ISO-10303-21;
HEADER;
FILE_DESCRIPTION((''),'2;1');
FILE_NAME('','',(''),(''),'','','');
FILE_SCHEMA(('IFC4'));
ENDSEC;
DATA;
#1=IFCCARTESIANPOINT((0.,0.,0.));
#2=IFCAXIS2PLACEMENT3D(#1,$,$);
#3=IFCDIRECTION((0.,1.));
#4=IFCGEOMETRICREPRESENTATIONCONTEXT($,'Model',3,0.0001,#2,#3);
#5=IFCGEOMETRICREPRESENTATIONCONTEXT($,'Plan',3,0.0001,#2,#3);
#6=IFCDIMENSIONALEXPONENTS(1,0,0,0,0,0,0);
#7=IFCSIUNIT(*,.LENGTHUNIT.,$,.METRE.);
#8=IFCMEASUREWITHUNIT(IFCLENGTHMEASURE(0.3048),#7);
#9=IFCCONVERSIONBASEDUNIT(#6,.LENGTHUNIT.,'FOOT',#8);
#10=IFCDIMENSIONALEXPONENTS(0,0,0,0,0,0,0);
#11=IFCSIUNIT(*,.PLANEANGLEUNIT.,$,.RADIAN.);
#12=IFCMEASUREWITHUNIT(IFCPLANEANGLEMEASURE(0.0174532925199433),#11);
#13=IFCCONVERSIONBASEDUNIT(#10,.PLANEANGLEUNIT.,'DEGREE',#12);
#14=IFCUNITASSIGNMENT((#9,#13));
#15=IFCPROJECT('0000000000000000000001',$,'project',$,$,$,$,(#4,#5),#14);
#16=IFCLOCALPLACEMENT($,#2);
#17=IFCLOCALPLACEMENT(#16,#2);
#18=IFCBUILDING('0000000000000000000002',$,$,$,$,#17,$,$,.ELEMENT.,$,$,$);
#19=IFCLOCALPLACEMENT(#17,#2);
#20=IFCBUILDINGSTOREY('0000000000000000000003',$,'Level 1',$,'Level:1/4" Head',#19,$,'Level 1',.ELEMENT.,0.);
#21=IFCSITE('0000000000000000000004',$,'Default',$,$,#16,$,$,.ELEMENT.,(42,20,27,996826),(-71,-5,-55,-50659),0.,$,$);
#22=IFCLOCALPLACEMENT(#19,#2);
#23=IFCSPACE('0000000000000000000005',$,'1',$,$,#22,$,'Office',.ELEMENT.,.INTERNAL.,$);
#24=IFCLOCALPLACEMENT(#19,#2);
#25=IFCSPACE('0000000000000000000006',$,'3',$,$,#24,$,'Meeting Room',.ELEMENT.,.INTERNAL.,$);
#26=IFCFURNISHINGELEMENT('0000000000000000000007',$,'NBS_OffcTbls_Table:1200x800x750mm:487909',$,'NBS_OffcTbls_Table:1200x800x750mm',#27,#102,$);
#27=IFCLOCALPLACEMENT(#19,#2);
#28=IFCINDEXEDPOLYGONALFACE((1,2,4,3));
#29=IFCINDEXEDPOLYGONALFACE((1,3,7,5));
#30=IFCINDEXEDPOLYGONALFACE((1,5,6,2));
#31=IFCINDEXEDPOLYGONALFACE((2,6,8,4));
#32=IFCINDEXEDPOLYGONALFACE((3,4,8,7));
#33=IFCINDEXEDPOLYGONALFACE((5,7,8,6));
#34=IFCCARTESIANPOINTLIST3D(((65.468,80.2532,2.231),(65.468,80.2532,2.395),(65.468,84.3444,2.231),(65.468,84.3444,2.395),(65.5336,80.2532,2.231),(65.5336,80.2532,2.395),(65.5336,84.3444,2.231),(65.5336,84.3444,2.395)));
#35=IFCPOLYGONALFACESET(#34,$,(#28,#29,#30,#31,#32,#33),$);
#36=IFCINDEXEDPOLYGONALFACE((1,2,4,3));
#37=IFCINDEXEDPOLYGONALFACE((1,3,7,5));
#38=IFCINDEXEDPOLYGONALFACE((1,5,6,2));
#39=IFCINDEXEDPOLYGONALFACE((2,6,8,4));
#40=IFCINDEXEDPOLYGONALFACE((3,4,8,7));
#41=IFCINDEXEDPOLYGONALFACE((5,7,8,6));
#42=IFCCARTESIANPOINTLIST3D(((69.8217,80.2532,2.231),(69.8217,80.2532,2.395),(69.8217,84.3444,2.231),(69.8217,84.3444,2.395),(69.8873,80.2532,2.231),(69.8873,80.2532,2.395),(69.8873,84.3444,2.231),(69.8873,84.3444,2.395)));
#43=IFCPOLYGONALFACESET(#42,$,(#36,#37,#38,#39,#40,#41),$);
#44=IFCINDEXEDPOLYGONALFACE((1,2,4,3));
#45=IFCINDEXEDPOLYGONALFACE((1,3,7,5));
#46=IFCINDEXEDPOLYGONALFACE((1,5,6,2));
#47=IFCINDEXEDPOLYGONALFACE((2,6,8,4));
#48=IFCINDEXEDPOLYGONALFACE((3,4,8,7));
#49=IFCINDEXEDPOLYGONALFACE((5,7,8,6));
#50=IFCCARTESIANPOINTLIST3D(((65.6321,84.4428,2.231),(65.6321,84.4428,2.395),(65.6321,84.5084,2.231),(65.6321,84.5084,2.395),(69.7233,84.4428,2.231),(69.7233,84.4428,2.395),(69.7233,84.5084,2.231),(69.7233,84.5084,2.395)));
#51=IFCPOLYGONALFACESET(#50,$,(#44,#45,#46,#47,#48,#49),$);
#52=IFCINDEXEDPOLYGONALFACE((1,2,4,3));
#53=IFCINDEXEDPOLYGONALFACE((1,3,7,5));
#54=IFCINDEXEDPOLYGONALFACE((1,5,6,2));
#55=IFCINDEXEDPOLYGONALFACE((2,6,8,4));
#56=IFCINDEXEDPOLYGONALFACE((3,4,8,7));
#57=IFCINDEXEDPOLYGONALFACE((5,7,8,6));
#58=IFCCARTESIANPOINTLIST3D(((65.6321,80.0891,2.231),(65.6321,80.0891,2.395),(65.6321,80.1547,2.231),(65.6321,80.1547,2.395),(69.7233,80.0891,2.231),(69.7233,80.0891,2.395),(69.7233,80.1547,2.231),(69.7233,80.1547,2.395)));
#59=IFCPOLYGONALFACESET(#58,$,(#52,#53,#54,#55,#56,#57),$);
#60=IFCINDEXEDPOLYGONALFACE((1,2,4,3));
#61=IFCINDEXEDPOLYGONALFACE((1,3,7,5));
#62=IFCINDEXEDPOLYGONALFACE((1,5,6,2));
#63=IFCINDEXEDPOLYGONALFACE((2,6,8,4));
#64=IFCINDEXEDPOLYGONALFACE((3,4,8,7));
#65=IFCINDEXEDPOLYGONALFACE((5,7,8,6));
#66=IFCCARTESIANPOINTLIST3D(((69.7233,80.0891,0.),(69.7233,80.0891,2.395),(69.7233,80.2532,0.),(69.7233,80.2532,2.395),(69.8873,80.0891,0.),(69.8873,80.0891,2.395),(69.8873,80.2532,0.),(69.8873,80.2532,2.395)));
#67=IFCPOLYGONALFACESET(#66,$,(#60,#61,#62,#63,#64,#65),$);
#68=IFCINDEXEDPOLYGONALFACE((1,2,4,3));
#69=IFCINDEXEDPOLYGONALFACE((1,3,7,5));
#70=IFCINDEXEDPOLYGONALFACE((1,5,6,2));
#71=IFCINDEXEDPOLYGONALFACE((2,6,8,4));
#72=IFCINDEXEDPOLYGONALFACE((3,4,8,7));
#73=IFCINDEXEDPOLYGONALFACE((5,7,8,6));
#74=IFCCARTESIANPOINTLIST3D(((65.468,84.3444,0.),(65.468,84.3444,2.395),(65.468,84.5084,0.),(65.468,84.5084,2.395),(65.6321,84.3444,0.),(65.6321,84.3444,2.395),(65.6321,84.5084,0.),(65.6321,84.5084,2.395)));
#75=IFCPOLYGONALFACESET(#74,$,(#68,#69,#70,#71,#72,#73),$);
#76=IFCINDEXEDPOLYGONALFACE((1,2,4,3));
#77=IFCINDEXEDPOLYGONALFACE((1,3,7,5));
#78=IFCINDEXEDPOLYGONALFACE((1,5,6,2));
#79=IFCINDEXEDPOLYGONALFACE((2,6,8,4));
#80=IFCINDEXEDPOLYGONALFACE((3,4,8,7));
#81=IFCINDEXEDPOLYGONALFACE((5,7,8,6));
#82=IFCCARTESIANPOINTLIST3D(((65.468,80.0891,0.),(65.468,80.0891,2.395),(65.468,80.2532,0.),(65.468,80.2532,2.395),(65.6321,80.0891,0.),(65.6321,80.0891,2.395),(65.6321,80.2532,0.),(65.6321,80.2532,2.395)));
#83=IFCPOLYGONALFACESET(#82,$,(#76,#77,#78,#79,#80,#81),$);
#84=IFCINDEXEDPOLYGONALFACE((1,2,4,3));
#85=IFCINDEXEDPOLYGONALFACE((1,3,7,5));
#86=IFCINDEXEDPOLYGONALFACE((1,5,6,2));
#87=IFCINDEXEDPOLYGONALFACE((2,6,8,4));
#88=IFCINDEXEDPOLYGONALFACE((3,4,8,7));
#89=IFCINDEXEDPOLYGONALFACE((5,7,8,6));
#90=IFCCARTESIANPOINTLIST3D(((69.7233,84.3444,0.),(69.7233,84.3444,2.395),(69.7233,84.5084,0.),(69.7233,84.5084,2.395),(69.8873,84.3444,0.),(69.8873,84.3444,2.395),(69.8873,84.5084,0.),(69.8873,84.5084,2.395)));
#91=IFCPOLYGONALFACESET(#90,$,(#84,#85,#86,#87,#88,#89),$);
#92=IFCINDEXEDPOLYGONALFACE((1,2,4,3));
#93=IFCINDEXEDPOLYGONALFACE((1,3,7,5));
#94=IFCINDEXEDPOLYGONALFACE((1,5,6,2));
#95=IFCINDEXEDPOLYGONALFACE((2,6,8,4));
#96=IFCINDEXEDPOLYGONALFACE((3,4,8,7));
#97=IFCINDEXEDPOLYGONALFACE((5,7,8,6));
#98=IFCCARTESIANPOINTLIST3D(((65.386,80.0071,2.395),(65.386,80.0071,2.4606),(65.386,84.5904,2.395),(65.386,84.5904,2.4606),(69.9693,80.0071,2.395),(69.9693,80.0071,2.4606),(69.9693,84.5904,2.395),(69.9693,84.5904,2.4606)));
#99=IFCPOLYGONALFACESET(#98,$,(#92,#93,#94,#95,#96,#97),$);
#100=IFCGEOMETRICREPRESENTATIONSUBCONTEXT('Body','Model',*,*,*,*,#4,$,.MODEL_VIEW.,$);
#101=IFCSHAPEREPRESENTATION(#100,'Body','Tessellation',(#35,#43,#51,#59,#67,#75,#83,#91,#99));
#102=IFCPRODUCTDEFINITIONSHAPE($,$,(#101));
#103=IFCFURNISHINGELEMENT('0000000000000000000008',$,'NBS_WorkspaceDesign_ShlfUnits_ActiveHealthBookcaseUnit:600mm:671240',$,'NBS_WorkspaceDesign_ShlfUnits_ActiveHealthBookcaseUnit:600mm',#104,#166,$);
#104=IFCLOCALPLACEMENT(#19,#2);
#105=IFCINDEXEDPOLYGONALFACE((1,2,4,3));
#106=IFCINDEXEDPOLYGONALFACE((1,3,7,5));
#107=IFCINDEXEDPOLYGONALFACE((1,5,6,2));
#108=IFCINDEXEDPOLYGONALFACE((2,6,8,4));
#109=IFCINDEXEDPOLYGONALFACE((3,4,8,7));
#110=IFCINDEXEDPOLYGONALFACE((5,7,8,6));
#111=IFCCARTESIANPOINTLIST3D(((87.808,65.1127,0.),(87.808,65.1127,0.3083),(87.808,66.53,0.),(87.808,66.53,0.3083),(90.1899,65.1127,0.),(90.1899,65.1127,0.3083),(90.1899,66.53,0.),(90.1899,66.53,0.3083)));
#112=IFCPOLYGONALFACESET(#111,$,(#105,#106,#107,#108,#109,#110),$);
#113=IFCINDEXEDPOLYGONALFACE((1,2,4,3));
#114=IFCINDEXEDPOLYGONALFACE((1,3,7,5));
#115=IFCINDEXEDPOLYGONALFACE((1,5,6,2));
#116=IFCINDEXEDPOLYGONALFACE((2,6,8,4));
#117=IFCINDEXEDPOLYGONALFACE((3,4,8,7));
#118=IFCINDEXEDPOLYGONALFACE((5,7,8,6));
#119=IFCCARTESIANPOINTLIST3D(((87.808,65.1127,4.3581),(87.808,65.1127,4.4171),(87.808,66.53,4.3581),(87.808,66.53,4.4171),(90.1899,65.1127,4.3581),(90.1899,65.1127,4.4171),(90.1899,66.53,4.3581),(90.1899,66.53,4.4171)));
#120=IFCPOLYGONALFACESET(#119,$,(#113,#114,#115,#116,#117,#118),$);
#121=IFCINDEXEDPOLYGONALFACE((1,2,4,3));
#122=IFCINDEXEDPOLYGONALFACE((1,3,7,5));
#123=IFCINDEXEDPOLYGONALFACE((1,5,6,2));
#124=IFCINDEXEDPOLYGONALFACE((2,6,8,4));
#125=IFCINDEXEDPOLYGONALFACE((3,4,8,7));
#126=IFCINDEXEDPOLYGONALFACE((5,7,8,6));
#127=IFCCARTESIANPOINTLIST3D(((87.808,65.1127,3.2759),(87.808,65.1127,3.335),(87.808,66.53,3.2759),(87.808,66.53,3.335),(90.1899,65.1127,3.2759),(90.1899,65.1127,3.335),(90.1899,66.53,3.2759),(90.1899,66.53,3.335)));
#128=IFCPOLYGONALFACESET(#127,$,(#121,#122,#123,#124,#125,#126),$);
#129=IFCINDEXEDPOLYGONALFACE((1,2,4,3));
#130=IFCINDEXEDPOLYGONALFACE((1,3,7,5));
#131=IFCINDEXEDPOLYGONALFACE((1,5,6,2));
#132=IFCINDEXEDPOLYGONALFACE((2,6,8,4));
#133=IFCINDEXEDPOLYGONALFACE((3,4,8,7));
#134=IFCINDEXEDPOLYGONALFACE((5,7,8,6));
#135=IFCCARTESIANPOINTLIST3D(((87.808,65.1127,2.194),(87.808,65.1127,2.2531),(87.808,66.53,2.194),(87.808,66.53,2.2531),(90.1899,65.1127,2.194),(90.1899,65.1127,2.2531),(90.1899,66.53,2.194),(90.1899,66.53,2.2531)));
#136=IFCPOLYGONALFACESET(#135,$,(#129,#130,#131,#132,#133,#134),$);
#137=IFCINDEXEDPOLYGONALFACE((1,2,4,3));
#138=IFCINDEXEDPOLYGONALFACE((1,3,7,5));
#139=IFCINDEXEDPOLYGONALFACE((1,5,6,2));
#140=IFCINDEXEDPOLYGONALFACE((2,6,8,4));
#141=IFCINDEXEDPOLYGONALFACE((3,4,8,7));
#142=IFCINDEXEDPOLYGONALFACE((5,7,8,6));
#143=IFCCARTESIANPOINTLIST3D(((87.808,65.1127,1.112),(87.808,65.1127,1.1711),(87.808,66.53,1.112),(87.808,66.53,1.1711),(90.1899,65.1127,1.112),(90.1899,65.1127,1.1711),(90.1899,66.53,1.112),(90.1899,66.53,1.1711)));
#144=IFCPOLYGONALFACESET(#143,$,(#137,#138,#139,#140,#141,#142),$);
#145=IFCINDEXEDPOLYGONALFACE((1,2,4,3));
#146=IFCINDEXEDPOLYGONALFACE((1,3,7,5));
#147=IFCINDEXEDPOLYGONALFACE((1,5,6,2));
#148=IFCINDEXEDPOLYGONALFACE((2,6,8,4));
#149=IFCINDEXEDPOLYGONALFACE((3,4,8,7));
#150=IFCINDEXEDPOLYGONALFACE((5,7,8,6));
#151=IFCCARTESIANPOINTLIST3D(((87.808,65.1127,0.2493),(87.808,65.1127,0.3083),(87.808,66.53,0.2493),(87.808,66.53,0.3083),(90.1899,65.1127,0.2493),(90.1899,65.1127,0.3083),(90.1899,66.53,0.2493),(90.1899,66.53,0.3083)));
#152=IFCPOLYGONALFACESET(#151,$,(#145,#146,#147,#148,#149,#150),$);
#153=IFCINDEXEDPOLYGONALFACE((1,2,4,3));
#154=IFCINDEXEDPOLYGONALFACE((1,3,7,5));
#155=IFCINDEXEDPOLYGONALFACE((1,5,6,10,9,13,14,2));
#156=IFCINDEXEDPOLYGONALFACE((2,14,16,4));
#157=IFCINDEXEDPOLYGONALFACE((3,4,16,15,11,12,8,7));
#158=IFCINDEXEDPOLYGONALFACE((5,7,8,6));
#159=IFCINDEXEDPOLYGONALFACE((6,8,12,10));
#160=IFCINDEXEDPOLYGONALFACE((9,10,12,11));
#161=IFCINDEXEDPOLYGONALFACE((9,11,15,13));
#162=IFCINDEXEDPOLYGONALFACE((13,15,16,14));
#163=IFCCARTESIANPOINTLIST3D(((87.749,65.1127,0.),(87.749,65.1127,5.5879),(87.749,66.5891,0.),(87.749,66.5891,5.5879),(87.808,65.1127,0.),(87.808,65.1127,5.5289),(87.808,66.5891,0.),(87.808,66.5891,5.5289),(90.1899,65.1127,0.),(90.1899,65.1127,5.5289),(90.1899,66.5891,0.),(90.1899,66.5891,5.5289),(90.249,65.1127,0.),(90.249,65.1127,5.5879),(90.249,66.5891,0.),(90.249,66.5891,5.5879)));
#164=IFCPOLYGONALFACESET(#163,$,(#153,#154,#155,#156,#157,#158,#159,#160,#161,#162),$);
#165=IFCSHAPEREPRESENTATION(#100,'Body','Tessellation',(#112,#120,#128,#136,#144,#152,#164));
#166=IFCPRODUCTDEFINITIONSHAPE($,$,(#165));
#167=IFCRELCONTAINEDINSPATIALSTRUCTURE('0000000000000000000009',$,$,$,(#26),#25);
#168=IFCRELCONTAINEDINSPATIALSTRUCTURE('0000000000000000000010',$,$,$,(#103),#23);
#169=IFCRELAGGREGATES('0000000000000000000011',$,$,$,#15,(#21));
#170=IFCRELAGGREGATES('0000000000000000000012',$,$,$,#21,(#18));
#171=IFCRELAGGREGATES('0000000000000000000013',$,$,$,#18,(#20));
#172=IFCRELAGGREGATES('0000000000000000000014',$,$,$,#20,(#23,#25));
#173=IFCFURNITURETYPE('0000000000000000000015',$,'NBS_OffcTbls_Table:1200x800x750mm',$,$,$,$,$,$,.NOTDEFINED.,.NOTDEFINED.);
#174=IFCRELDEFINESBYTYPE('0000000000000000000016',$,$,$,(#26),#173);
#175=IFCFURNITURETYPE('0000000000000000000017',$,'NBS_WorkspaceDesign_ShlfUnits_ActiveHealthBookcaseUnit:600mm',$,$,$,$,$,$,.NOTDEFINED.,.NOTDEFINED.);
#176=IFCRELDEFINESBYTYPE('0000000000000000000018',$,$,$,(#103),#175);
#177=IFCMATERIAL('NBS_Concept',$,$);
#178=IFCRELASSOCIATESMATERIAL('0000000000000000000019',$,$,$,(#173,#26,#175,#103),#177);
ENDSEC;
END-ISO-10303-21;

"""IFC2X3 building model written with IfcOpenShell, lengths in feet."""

from ifc_helpers import new_model, entity, si_unit, converted_unit, direction, frame, frame_2d, origin, origin_2d_with_axis, place, context, subcontext, project, spatial, polyline, rectangle, outline, extrude, source, transform, mapped, material, type_object, type_shapes, element, save


model = new_model("IFC2X3")

# Units and contexts
model_context = context("Model", 3, precision=0.0001, world=origin(), true_north=direction((0.0, 1.0)))
plan_context = context("Plan", 3, precision=0.0001, world=origin(), true_north=direction((0.0, 1.0)))
body_context = subcontext(model_context, "Body", "Model", "MODEL_VIEW")
ifc_project = project(units=[converted_unit("LENGTHUNIT", "FOOT", entity("IfcLengthMeasure", 0.3048), si_unit("LENGTHUNIT", "METRE"), dimensions=[1, 0, 0, 0, 0, 0, 0]), converted_unit("PLANEANGLEUNIT", "DEGREE", entity("IfcPlaneAngleMeasure", 0.0174532925199433), si_unit("PLANEANGLEUNIT", "RADIAN"), dimensions=[0, 0, 0, 0, 0, 0, 0])], contexts=[model_context, plan_context])

# Site, building, storey
site_placement = place(None, origin())
site = spatial("IfcSite", under=ifc_project, at=site_placement, Name="Default", CompositionType="ELEMENT", RefLatitude=(42, 20, 27, 996826), RefLongitude=(-71, -5, -55, -50659), RefElevation=0.0)
building_placement = place(site_placement, origin())
building = spatial("IfcBuilding", under=site, at=building_placement, CompositionType="ELEMENT")
storey_placement = place(building_placement, origin())
storey = spatial("IfcBuildingStorey", under=building, at=storey_placement, Name="Level 1", ObjectType="Level:1/4\" Head", LongName="Level 1", CompositionType="ELEMENT", Elevation=0.0)

# Shared definitions
space_1_placement = place(storey_placement, origin())
space_1 = spatial("IfcSpace", under=storey, at=space_1_placement, Name="1", LongName="Office", CompositionType="ELEMENT", InteriorOrExteriorSpace="INTERNAL")

# Shared definitions
space_2_placement = place(storey_placement, origin())
space_2 = spatial("IfcSpace", under=storey, at=space_2_placement, Name="3", LongName="Meeting Room", CompositionType="ELEMENT", InteriorOrExteriorSpace="INTERNAL")

# Furnishing elements
ifc_material_1 = material(Name="NBS_Concept")
furniture_type_1 = type_object("IfcFurnitureType", Name="NBS_OffcTbls_Table:1200x800x750mm", AssemblyPlace="NOTDEFINED", material=ifc_material_1)
shared_shape_1 = source(origin(), body_context, "Body", "SweptSolid", [
    extrude(rectangle(XDim=0.0656, YDim=4.0912, at=frame_2d((0.0, 0.0), x_axis=(1.0, 0.0))), frame((-2.1768, 0.0, 2.231)), (0.0, 0.0, 1.0), 0.164),
    extrude(rectangle(XDim=4.0912, YDim=0.0656, at=frame_2d((0.0, 0.0), x_axis=(1.0, 0.0))), frame((2.1768, 0.0, 2.231), z_axis=(0.0, 0.0, 1.0), x_axis=(0.0, -1.0, 0.0)), (0.0, 0.0, 1.0), 0.164),
    extrude(rectangle(XDim=4.0912, YDim=0.0656, at=origin_2d_with_axis()), frame((0.0, 2.1768, 2.231), z_axis=(0.0, 0.0, 1.0), x_axis=(-1.0, 0.0, 0.0)), (0.0, 0.0, 1.0), 0.164),
    extrude(rectangle(XDim=4.0912, YDim=0.0656, at=origin_2d_with_axis()), frame((0.0, -2.1768, 2.231)), (0.0, 0.0, 1.0), 0.164),
    extrude(rectangle(XDim=0.164, YDim=0.164, at=origin_2d_with_axis()), frame((2.1276, -2.1276, 0.0), z_axis=(0.0, 0.0, 1.0), x_axis=(-1.0, 0.0, 0.0)), (0.0, 0.0, 1.0), 2.395),
    extrude(rectangle(XDim=0.164, YDim=0.164, at=frame_2d((0.0, 0.0), x_axis=(1.0, 0.0))), frame((-2.1276, 2.1276, 0.0), z_axis=(0.0, 0.0, 1.0), x_axis=(-1.0, 0.0, 0.0)), (0.0, 0.0, 1.0), 2.395),
    extrude(rectangle(XDim=0.164, YDim=0.164, at=origin_2d_with_axis()), frame((-2.1276, -2.1276, 0.0), z_axis=(0.0, 0.0, 1.0), x_axis=(-1.0, 0.0, 0.0)), (0.0, 0.0, 1.0), 2.395),
    extrude(rectangle(XDim=0.164, YDim=0.164, at=frame_2d((0.0, 0.0), x_axis=(1.0, 0.0))), frame((2.1276, 2.1276, 0.0)), (0.0, 0.0, 1.0), 2.395),
    extrude(rectangle(XDim=4.5833, YDim=4.5833, at=origin_2d_with_axis()), frame((0.0, 0.0, 2.395)), (0.0, 0.0, 1.0), 0.0656),
])
type_shapes(furniture_type_1, [shared_shape_1])
furnishing_1_placement = place(space_2_placement, frame((67.6777, 82.2988, 0.0)))
element("IfcFurnishingElement", 1, at=furnishing_1_placement, inside=space_2, type_object=furniture_type_1, material=ifc_material_1, Name="NBS_OffcTbls_Table:1200x800x750mm:487909", ObjectType="NBS_OffcTbls_Table:1200x800x750mm", context=body_context, shape_type="MappedRepresentation", body=[
    mapped(shared_shape_1, transform((0.0, 0.0, 0.0), scale=1.0)),
])
furniture_type_2 = type_object("IfcFurnitureType", Name="NBS_WorkspaceDesign_ShlfUnits_ActiveHealthBookcaseUnit:600mm", AssemblyPlace="NOTDEFINED", material=ifc_material_1)
shared_shape_2 = source(origin(), body_context, "Body", "SweptSolid", [
    extrude(rectangle(XDim=1.4173, YDim=2.3819, at=frame_2d((0.0, 0.0), x_axis=(1.0, 0.0))), frame((0.0, -0.7677, 0.0), z_axis=(0.0, 0.0, 1.0), x_axis=(0.0, 1.0, 0.0)), (0.0, 0.0, 1.0), 0.3083),
    extrude(rectangle(XDim=1.4173, YDim=2.3819, at=frame_2d((0.0, 0.0), x_axis=(1.0, 0.0))), frame((0.0, -0.7677, 4.3581), z_axis=(0.0, 0.0, 1.0), x_axis=(0.0, 1.0, 0.0)), (0.0, 0.0, 1.0), 0.0591),
    extrude(rectangle(XDim=1.4173, YDim=2.3819, at=frame_2d((0.0, 0.0), x_axis=(1.0, 0.0))), frame((0.0, -0.7677, 3.2759), z_axis=(0.0, 0.0, 1.0), x_axis=(0.0, 1.0, 0.0)), (0.0, 0.0, 1.0), 0.0591),
    extrude(rectangle(XDim=1.4173, YDim=2.3819, at=frame_2d((0.0, 0.0), x_axis=(1.0, 0.0))), frame((0.0, -0.7677, 2.194), z_axis=(0.0, 0.0, 1.0), x_axis=(0.0, 1.0, 0.0)), (0.0, 0.0, 1.0), 0.0591),
    extrude(rectangle(XDim=1.4173, YDim=2.3819, at=frame_2d((0.0, 0.0), x_axis=(1.0, 0.0))), frame((0.0, -0.7677, 1.112), z_axis=(0.0, 0.0, 1.0), x_axis=(0.0, 1.0, 0.0)), (0.0, 0.0, 1.0), 0.0591),
    extrude(rectangle(XDim=1.4173, YDim=2.3819, at=frame_2d((0.0, 0.0), x_axis=(1.0, 0.0))), frame((0.0, -0.7677, 0.2493), z_axis=(0.0, 0.0, 1.0), x_axis=(0.0, 1.0, 0.0)), (0.0, 0.0, 1.0), 0.0591),
    extrude(outline(polyline([(-2.8087, -1.25), (2.7792, -1.25), (2.7792, -1.1909), (-2.7497, -1.1909), (-2.7497, 1.1909), (2.7792, 1.1909), (2.7792, 1.25), (-2.8087, 1.25), (-2.8087, -1.25)])), frame((0.0, -1.4764, 2.7792), z_axis=(0.0, 1.0, 0.0), x_axis=(0.0, 0.0, -1.0)), (0.0, 0.0, 1.0), 1.4764),
])
type_shapes(furniture_type_2, [shared_shape_2])
furnishing_2_placement = place(space_1_placement, frame((88.999, 66.5891, 0.0)))
element("IfcFurnishingElement", 2, at=furnishing_2_placement, inside=space_1, type_object=furniture_type_2, material=ifc_material_1, Name="NBS_WorkspaceDesign_ShlfUnits_ActiveHealthBookcaseUnit:600mm:671240", ObjectType="NBS_WorkspaceDesign_ShlfUnits_ActiveHealthBookcaseUnit:600mm", context=body_context, shape_type="MappedRepresentation", body=[
    mapped(shared_shape_2, transform((0.0, 0.0, 0.0), scale=1.0)),
])

save(model, "model.ifc")
